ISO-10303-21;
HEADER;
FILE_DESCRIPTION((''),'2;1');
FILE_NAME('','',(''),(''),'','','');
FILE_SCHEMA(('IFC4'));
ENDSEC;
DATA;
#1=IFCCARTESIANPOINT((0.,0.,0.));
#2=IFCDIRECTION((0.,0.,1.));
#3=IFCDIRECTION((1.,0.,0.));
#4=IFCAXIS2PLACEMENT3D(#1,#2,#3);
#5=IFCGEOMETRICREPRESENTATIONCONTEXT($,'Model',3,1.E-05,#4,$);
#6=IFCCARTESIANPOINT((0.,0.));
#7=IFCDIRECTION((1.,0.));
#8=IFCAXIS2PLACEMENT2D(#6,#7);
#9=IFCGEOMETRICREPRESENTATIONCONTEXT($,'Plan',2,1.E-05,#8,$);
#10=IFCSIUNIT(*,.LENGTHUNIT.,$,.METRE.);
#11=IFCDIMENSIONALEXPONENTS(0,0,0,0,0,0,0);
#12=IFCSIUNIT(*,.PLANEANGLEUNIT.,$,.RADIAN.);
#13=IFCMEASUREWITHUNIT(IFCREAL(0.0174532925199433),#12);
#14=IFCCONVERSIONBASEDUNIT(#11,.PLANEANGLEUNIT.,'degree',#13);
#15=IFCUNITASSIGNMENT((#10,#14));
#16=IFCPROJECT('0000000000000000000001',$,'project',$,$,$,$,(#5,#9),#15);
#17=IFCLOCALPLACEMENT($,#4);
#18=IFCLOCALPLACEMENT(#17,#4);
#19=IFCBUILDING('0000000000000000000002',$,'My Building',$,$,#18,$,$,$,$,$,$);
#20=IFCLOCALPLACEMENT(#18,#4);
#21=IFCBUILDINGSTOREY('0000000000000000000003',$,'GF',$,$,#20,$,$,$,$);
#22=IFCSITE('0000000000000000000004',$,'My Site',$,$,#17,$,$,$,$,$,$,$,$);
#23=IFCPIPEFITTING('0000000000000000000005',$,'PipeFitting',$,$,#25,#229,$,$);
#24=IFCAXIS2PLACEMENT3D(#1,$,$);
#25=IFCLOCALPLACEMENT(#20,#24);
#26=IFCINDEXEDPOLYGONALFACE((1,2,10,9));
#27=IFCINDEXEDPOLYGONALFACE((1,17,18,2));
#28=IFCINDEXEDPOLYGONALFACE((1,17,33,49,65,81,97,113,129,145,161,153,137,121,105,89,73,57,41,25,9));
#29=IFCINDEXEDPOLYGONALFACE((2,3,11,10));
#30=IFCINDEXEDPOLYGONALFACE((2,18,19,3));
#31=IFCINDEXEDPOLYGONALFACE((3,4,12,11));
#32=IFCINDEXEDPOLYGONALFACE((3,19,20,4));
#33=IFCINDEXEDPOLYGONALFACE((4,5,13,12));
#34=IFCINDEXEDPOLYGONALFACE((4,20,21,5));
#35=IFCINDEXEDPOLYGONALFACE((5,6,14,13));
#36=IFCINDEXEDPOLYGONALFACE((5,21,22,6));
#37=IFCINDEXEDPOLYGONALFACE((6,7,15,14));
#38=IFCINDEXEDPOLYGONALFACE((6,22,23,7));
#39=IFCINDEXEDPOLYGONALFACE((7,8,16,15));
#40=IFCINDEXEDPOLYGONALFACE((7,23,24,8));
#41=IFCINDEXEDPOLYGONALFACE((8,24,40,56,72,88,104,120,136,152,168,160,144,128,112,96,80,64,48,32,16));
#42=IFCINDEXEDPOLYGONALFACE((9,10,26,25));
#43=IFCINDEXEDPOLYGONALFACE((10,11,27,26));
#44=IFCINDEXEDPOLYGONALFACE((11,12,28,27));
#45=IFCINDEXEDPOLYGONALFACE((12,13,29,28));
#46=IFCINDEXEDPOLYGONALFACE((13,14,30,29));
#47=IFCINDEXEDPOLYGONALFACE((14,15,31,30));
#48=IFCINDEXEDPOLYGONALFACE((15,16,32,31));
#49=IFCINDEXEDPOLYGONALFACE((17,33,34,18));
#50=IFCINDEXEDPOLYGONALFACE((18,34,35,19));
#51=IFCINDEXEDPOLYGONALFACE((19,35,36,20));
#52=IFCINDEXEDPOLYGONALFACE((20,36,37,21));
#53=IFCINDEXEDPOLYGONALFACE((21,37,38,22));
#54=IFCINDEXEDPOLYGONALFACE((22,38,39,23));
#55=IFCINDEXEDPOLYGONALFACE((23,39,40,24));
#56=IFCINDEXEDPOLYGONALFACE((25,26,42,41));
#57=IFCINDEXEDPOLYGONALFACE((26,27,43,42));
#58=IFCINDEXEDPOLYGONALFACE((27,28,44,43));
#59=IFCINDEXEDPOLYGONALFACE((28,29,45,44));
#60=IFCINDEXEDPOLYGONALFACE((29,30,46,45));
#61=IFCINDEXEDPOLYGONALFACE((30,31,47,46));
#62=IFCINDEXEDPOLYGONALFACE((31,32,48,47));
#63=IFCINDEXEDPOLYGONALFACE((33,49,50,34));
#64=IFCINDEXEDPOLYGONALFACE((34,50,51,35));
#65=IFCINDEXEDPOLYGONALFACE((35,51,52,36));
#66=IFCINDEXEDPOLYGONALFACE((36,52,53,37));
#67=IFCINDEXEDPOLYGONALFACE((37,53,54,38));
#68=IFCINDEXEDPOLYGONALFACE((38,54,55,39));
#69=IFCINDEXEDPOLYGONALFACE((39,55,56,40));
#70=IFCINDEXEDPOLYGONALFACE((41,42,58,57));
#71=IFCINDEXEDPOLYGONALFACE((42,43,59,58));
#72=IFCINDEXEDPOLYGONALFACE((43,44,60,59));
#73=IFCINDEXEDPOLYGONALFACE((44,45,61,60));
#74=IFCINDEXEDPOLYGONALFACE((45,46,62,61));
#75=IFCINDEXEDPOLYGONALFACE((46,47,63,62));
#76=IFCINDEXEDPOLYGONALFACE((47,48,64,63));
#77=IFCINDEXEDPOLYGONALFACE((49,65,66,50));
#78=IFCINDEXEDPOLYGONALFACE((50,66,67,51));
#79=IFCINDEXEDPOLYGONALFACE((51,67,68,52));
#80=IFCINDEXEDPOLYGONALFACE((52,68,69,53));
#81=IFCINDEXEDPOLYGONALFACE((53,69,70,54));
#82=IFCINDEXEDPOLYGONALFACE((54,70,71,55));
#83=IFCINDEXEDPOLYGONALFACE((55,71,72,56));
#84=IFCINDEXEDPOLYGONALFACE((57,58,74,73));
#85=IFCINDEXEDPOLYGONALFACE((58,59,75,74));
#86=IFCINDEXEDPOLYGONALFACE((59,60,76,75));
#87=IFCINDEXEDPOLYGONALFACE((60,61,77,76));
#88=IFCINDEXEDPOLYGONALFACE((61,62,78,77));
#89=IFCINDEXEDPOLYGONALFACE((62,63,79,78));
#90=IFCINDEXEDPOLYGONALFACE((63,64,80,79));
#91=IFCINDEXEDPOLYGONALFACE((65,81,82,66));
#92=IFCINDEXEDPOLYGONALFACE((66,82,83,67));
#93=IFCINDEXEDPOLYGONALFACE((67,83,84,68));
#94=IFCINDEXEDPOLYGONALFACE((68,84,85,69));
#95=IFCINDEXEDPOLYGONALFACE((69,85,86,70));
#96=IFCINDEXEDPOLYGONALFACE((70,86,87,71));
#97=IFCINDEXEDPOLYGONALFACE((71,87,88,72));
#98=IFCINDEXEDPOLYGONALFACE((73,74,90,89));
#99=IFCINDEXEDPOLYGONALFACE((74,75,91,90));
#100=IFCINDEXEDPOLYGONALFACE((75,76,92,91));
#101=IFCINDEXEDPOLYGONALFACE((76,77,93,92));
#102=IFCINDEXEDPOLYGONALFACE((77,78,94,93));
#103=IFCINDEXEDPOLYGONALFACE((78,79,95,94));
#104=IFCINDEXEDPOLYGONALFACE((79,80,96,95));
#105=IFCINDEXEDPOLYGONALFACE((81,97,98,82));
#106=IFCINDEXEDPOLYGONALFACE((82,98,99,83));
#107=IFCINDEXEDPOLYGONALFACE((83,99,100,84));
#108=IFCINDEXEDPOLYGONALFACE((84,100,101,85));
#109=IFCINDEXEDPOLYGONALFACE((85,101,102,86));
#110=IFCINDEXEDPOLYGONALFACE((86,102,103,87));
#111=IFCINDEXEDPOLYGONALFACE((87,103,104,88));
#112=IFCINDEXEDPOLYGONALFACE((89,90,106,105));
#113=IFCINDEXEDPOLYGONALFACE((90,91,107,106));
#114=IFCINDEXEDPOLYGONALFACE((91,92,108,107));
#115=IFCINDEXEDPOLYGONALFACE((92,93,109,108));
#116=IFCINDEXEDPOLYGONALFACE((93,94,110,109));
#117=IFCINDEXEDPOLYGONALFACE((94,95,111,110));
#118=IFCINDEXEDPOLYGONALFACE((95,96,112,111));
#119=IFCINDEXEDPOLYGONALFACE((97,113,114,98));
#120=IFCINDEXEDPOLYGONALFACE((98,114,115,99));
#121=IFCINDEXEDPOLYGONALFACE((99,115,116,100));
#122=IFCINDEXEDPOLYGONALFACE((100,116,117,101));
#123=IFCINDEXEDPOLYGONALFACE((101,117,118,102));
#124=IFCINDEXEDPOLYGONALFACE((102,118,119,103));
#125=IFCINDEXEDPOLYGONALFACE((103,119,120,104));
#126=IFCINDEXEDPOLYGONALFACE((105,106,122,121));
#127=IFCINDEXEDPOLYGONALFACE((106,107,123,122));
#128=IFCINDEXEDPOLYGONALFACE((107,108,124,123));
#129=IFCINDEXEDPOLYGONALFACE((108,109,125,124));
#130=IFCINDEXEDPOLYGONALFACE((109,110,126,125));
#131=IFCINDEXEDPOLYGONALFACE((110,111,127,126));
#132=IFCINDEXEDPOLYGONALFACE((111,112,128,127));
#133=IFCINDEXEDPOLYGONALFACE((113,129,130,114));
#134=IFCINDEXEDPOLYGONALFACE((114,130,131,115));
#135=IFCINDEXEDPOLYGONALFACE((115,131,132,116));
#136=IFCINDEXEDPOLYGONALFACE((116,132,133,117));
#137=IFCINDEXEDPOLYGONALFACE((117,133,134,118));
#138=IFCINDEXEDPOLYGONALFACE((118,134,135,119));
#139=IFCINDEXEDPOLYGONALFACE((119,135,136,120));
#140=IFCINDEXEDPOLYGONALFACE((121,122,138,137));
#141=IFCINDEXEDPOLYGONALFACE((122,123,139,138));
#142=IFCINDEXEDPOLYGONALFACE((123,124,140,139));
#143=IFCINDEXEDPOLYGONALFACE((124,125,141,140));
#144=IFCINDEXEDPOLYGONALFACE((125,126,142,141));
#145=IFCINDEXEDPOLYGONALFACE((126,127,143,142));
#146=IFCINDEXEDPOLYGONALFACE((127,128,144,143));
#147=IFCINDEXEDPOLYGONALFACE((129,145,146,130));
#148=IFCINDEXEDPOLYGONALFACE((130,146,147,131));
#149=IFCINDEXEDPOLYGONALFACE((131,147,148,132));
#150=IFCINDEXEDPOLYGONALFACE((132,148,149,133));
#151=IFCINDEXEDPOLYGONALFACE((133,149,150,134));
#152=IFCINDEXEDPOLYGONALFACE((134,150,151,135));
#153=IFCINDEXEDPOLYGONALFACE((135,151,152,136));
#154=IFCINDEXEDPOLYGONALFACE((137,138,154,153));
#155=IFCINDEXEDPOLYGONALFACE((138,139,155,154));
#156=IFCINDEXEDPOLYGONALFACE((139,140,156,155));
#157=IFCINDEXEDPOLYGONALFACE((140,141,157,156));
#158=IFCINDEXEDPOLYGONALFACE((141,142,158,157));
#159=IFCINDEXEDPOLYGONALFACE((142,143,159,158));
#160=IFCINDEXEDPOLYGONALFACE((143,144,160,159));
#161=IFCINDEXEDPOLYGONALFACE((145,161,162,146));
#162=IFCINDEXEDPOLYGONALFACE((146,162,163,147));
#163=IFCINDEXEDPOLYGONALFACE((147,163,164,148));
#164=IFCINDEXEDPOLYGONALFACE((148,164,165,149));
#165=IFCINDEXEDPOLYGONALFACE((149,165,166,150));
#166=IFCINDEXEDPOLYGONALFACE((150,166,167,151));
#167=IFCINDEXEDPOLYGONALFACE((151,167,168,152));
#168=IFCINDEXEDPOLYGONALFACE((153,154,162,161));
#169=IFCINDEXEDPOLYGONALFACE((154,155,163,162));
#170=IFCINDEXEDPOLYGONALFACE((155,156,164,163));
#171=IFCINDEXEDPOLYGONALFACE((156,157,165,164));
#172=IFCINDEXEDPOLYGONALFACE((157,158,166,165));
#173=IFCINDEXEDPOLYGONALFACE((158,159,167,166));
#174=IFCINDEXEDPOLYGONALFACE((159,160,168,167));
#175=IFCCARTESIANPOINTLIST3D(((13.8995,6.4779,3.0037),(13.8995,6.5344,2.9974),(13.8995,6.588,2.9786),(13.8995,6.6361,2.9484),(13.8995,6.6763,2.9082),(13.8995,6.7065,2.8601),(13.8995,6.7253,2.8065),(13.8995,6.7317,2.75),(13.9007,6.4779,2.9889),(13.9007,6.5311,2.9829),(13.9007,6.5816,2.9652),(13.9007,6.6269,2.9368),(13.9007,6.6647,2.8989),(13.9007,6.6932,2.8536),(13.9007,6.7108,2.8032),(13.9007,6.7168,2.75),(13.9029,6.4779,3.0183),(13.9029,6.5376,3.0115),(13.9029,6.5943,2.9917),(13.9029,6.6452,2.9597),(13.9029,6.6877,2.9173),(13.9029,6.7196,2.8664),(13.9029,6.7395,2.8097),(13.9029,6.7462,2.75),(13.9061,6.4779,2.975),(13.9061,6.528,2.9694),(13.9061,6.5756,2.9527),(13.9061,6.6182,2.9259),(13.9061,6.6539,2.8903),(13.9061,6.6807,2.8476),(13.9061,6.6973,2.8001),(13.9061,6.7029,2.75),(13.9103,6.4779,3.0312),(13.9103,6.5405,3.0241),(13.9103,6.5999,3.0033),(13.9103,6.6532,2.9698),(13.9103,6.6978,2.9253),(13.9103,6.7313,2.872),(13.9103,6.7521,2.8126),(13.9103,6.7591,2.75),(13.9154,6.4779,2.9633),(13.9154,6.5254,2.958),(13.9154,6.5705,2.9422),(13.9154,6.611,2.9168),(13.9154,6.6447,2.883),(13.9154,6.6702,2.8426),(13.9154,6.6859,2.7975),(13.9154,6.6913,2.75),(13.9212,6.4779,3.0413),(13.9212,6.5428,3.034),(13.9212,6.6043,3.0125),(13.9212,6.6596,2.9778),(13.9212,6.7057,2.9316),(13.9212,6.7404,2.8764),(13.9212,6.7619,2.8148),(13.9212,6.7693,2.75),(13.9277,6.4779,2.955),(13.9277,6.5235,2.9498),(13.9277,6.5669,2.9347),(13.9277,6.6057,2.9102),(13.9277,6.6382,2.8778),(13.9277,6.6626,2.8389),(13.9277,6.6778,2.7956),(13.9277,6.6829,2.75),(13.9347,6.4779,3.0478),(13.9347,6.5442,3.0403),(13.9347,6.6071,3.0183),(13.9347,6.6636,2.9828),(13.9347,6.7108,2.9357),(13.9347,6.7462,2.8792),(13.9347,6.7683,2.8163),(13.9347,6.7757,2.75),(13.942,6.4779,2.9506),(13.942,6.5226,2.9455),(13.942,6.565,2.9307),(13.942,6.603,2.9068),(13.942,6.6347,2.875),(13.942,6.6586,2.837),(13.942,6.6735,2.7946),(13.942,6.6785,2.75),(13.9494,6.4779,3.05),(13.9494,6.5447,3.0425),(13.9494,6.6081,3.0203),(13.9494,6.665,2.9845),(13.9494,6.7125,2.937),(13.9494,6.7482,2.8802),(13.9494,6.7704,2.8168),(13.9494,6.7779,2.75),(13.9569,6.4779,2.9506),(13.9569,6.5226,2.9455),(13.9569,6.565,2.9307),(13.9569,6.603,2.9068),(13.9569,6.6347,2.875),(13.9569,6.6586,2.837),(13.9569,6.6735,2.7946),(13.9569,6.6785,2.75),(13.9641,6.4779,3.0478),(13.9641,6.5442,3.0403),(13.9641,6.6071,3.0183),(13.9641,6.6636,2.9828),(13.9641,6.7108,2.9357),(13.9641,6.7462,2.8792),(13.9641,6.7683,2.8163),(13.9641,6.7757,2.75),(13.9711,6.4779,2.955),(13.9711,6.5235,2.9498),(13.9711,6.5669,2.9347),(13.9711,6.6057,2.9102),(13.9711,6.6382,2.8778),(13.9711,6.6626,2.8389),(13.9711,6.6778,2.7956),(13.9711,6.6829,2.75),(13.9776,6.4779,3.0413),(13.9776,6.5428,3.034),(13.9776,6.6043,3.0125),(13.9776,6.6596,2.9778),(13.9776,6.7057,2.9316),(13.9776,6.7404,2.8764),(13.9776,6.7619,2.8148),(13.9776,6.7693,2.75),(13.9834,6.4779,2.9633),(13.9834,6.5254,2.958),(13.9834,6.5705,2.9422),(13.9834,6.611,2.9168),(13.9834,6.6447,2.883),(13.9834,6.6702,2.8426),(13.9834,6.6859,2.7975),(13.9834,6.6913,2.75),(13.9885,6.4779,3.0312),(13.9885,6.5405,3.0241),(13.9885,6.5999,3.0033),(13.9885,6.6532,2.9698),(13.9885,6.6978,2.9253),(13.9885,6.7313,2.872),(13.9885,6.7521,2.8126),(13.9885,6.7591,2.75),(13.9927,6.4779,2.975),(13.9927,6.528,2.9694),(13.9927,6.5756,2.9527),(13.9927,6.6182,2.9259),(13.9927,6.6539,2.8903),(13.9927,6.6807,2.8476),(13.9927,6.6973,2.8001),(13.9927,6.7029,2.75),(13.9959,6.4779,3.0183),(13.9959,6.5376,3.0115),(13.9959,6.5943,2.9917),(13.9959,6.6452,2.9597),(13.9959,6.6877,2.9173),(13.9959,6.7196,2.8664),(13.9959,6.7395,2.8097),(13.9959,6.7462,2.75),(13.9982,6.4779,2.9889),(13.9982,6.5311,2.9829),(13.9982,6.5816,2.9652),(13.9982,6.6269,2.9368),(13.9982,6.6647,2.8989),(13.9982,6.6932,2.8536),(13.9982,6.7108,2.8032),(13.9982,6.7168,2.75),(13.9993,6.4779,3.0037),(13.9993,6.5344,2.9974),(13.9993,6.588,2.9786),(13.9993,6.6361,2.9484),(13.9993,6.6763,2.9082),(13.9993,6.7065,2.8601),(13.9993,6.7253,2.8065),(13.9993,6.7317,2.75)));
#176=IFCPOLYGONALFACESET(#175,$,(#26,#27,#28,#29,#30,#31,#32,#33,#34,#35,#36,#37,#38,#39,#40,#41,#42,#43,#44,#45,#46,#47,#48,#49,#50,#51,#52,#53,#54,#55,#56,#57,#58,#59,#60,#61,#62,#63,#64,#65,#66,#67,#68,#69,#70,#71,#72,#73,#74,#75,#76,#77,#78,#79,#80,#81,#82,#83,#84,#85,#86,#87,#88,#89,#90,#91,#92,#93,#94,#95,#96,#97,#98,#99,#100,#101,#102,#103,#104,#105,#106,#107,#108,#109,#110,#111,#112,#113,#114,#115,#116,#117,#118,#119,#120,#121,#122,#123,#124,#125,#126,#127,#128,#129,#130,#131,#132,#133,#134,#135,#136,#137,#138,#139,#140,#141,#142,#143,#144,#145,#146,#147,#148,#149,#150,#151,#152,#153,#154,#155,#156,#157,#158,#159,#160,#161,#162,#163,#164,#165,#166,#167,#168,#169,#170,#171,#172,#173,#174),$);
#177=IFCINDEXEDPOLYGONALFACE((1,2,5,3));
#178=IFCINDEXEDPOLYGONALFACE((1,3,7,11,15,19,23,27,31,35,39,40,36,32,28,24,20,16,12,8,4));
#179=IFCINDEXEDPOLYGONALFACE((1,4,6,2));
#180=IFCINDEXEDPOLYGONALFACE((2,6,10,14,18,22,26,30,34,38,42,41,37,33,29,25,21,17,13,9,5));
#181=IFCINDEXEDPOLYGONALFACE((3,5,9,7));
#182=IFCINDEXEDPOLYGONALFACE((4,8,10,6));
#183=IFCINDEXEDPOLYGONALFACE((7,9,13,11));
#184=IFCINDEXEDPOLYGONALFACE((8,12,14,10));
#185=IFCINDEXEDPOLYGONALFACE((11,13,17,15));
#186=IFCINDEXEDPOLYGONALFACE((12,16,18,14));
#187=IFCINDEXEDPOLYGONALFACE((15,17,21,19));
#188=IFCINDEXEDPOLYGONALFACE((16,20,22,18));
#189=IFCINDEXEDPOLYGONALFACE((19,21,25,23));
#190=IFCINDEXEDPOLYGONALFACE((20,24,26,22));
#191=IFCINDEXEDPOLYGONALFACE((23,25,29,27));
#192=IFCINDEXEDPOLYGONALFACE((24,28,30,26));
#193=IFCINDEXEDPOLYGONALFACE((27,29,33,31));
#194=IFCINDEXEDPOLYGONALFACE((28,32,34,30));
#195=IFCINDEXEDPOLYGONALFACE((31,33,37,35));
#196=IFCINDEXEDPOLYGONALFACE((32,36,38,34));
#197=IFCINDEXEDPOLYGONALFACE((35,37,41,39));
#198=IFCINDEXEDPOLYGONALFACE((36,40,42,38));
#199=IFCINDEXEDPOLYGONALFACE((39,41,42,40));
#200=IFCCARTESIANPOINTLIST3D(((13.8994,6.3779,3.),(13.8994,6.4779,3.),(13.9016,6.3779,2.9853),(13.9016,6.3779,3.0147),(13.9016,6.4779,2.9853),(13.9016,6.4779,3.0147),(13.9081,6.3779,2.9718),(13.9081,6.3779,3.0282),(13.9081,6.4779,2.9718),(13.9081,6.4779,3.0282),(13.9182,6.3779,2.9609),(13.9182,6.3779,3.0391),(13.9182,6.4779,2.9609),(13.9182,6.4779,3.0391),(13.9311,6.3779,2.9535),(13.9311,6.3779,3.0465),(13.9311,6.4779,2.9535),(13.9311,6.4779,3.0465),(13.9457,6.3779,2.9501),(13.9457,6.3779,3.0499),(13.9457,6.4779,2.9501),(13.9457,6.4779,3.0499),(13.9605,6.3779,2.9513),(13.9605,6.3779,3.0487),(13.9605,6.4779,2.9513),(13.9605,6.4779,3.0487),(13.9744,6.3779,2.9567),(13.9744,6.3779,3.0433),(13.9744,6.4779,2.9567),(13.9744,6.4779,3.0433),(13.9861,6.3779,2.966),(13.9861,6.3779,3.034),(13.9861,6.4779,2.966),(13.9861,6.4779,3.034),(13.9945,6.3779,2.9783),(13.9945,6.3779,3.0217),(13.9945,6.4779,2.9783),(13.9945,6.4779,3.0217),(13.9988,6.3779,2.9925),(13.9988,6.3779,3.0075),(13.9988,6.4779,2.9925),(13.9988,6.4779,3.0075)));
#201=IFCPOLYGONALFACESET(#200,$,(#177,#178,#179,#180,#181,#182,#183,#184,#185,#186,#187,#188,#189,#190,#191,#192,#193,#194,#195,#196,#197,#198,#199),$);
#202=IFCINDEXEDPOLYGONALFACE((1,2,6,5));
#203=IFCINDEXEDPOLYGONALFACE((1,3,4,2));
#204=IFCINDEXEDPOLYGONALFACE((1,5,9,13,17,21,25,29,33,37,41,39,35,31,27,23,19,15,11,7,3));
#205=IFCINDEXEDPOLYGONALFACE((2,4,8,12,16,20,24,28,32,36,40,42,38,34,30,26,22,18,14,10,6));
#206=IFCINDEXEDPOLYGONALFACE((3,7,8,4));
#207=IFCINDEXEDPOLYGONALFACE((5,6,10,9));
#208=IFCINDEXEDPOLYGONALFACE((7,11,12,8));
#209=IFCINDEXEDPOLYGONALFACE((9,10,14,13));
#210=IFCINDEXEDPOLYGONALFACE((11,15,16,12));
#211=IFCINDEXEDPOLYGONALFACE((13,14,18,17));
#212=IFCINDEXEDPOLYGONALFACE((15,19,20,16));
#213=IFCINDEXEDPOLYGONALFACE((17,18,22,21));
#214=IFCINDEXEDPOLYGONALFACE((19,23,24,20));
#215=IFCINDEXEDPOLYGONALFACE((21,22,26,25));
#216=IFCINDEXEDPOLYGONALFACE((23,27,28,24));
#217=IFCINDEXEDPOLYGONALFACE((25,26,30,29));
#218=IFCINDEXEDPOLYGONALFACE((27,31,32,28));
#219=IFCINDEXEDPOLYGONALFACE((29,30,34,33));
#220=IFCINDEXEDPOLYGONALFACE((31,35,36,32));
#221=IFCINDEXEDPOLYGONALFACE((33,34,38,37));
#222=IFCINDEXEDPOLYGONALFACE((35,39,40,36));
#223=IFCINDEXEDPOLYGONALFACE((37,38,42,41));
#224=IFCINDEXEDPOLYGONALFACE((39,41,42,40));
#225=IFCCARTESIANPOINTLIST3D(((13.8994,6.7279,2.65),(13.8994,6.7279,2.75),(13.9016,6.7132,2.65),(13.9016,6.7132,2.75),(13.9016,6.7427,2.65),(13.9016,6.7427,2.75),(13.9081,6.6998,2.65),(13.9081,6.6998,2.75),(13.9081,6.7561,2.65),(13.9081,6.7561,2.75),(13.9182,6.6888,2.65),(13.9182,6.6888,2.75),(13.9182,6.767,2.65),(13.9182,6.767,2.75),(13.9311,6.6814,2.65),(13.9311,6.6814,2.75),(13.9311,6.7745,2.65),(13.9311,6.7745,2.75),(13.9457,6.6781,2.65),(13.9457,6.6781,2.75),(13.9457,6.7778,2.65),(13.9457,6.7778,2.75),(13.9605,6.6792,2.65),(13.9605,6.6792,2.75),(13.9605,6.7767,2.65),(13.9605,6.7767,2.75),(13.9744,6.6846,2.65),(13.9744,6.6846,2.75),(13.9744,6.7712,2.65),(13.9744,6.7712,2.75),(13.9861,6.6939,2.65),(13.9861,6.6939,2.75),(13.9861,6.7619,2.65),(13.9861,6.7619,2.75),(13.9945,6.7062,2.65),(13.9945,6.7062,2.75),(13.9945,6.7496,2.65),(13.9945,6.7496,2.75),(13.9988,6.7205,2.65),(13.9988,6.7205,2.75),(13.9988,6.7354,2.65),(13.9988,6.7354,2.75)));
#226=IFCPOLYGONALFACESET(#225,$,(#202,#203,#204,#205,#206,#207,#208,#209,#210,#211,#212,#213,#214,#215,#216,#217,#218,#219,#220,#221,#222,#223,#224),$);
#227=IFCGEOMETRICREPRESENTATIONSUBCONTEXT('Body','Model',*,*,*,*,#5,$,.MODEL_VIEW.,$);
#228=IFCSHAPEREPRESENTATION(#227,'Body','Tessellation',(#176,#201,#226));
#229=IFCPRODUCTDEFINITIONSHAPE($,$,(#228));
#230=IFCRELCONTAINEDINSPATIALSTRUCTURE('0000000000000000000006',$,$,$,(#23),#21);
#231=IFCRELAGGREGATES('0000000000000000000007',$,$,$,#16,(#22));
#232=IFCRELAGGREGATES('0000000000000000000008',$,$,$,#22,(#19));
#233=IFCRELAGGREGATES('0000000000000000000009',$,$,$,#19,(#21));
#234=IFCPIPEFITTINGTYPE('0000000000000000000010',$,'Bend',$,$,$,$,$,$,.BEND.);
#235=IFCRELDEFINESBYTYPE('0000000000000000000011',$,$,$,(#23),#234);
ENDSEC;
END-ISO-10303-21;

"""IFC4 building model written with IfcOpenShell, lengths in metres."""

from ifc_helpers import new_model, entity, si_unit, converted_unit, frame, origin_with_axes, origin_2d_with_axis, place, context, subcontext, project, spatial, circle, extrude, source, transform, mapped, type_object, type_shapes, element, save


model = new_model("IFC4")

# Units and contexts
model_context = context("Model", 3, precision=1e-05, world=origin_with_axes())
plan_context = context("Plan", 2, precision=1e-05, world=origin_2d_with_axis())
body_context = subcontext(model_context, "Body", "Model", "MODEL_VIEW")
ifc_project = project(units=[si_unit("LENGTHUNIT", "METRE"), converted_unit("PLANEANGLEUNIT", "degree", entity("IfcReal", 0.0174532925199433), si_unit("PLANEANGLEUNIT", "RADIAN"), dimensions=[0, 0, 0, 0, 0, 0, 0])], contexts=[model_context, plan_context])

# Site, building, storey
site_placement = place(None, origin_with_axes())
site = spatial("IfcSite", under=ifc_project, at=site_placement, Name="My Site")
building_placement = place(site_placement, origin_with_axes())
building = spatial("IfcBuilding", under=site, at=building_placement, Name="My Building")
storey_placement = place(building_placement, origin_with_axes())
storey = spatial("IfcBuildingStorey", under=building, at=storey_placement, Name="GF")

# Pipe fitting
pipe_fitting_type = type_object("IfcPipeFittingType", Name="Bend", PredefinedType="BEND")
shared_shape = source(origin_with_axes(), body_context, "Body", "SolidModel", [
    entity("IfcSweptDiskSolid", entity("IfcIndexedPolyCurve", entity("IfcCartesianPointList3D", [[0.0, 0.0, 0.1], [0.0, -0.0732, 0.2768], [0.0, -0.25, 0.35]]), [entity("IfcArcIndex", [1, 2, 3])]), 0.05),
    extrude(circle(Radius=0.05), origin_with_axes(), (0.0, 0.0, 1.0), 0.1),
    extrude(circle(Radius=0.05), frame((0.0, -0.25, 0.35), z_axis=(0.0, -1.0, 0.0), x_axis=(1.0, 0.0, 0.0)), (0.0, 0.0, 1.0), 0.1),
])
type_shapes(pipe_fitting_type, [shared_shape])
for number, where, z_axis, x_axis, name in (
    (1, (13.9494, 6.3779, 3.0), (0.0, 1.0, 0.0), (-1.0, 0.0, 0.0), "PipeFitting"),
):
    element("IfcPipeFitting", number, at=place(storey_placement, frame(where, z_axis=z_axis, x_axis=x_axis)), inside=storey, type_object=pipe_fitting_type, Name=name, context=body_context, shape_type="MappedRepresentation", body=[
        mapped(shared_shape, transform((0.0, 0.0, 0.0), x_axis=(1.0, 0.0, 0.0), y_axis=(0.0, 1.0, 0.0), z_axis=(0.0, 0.0, 1.0), scale=1.0)),
    ])

save(model, "model.ifc")
